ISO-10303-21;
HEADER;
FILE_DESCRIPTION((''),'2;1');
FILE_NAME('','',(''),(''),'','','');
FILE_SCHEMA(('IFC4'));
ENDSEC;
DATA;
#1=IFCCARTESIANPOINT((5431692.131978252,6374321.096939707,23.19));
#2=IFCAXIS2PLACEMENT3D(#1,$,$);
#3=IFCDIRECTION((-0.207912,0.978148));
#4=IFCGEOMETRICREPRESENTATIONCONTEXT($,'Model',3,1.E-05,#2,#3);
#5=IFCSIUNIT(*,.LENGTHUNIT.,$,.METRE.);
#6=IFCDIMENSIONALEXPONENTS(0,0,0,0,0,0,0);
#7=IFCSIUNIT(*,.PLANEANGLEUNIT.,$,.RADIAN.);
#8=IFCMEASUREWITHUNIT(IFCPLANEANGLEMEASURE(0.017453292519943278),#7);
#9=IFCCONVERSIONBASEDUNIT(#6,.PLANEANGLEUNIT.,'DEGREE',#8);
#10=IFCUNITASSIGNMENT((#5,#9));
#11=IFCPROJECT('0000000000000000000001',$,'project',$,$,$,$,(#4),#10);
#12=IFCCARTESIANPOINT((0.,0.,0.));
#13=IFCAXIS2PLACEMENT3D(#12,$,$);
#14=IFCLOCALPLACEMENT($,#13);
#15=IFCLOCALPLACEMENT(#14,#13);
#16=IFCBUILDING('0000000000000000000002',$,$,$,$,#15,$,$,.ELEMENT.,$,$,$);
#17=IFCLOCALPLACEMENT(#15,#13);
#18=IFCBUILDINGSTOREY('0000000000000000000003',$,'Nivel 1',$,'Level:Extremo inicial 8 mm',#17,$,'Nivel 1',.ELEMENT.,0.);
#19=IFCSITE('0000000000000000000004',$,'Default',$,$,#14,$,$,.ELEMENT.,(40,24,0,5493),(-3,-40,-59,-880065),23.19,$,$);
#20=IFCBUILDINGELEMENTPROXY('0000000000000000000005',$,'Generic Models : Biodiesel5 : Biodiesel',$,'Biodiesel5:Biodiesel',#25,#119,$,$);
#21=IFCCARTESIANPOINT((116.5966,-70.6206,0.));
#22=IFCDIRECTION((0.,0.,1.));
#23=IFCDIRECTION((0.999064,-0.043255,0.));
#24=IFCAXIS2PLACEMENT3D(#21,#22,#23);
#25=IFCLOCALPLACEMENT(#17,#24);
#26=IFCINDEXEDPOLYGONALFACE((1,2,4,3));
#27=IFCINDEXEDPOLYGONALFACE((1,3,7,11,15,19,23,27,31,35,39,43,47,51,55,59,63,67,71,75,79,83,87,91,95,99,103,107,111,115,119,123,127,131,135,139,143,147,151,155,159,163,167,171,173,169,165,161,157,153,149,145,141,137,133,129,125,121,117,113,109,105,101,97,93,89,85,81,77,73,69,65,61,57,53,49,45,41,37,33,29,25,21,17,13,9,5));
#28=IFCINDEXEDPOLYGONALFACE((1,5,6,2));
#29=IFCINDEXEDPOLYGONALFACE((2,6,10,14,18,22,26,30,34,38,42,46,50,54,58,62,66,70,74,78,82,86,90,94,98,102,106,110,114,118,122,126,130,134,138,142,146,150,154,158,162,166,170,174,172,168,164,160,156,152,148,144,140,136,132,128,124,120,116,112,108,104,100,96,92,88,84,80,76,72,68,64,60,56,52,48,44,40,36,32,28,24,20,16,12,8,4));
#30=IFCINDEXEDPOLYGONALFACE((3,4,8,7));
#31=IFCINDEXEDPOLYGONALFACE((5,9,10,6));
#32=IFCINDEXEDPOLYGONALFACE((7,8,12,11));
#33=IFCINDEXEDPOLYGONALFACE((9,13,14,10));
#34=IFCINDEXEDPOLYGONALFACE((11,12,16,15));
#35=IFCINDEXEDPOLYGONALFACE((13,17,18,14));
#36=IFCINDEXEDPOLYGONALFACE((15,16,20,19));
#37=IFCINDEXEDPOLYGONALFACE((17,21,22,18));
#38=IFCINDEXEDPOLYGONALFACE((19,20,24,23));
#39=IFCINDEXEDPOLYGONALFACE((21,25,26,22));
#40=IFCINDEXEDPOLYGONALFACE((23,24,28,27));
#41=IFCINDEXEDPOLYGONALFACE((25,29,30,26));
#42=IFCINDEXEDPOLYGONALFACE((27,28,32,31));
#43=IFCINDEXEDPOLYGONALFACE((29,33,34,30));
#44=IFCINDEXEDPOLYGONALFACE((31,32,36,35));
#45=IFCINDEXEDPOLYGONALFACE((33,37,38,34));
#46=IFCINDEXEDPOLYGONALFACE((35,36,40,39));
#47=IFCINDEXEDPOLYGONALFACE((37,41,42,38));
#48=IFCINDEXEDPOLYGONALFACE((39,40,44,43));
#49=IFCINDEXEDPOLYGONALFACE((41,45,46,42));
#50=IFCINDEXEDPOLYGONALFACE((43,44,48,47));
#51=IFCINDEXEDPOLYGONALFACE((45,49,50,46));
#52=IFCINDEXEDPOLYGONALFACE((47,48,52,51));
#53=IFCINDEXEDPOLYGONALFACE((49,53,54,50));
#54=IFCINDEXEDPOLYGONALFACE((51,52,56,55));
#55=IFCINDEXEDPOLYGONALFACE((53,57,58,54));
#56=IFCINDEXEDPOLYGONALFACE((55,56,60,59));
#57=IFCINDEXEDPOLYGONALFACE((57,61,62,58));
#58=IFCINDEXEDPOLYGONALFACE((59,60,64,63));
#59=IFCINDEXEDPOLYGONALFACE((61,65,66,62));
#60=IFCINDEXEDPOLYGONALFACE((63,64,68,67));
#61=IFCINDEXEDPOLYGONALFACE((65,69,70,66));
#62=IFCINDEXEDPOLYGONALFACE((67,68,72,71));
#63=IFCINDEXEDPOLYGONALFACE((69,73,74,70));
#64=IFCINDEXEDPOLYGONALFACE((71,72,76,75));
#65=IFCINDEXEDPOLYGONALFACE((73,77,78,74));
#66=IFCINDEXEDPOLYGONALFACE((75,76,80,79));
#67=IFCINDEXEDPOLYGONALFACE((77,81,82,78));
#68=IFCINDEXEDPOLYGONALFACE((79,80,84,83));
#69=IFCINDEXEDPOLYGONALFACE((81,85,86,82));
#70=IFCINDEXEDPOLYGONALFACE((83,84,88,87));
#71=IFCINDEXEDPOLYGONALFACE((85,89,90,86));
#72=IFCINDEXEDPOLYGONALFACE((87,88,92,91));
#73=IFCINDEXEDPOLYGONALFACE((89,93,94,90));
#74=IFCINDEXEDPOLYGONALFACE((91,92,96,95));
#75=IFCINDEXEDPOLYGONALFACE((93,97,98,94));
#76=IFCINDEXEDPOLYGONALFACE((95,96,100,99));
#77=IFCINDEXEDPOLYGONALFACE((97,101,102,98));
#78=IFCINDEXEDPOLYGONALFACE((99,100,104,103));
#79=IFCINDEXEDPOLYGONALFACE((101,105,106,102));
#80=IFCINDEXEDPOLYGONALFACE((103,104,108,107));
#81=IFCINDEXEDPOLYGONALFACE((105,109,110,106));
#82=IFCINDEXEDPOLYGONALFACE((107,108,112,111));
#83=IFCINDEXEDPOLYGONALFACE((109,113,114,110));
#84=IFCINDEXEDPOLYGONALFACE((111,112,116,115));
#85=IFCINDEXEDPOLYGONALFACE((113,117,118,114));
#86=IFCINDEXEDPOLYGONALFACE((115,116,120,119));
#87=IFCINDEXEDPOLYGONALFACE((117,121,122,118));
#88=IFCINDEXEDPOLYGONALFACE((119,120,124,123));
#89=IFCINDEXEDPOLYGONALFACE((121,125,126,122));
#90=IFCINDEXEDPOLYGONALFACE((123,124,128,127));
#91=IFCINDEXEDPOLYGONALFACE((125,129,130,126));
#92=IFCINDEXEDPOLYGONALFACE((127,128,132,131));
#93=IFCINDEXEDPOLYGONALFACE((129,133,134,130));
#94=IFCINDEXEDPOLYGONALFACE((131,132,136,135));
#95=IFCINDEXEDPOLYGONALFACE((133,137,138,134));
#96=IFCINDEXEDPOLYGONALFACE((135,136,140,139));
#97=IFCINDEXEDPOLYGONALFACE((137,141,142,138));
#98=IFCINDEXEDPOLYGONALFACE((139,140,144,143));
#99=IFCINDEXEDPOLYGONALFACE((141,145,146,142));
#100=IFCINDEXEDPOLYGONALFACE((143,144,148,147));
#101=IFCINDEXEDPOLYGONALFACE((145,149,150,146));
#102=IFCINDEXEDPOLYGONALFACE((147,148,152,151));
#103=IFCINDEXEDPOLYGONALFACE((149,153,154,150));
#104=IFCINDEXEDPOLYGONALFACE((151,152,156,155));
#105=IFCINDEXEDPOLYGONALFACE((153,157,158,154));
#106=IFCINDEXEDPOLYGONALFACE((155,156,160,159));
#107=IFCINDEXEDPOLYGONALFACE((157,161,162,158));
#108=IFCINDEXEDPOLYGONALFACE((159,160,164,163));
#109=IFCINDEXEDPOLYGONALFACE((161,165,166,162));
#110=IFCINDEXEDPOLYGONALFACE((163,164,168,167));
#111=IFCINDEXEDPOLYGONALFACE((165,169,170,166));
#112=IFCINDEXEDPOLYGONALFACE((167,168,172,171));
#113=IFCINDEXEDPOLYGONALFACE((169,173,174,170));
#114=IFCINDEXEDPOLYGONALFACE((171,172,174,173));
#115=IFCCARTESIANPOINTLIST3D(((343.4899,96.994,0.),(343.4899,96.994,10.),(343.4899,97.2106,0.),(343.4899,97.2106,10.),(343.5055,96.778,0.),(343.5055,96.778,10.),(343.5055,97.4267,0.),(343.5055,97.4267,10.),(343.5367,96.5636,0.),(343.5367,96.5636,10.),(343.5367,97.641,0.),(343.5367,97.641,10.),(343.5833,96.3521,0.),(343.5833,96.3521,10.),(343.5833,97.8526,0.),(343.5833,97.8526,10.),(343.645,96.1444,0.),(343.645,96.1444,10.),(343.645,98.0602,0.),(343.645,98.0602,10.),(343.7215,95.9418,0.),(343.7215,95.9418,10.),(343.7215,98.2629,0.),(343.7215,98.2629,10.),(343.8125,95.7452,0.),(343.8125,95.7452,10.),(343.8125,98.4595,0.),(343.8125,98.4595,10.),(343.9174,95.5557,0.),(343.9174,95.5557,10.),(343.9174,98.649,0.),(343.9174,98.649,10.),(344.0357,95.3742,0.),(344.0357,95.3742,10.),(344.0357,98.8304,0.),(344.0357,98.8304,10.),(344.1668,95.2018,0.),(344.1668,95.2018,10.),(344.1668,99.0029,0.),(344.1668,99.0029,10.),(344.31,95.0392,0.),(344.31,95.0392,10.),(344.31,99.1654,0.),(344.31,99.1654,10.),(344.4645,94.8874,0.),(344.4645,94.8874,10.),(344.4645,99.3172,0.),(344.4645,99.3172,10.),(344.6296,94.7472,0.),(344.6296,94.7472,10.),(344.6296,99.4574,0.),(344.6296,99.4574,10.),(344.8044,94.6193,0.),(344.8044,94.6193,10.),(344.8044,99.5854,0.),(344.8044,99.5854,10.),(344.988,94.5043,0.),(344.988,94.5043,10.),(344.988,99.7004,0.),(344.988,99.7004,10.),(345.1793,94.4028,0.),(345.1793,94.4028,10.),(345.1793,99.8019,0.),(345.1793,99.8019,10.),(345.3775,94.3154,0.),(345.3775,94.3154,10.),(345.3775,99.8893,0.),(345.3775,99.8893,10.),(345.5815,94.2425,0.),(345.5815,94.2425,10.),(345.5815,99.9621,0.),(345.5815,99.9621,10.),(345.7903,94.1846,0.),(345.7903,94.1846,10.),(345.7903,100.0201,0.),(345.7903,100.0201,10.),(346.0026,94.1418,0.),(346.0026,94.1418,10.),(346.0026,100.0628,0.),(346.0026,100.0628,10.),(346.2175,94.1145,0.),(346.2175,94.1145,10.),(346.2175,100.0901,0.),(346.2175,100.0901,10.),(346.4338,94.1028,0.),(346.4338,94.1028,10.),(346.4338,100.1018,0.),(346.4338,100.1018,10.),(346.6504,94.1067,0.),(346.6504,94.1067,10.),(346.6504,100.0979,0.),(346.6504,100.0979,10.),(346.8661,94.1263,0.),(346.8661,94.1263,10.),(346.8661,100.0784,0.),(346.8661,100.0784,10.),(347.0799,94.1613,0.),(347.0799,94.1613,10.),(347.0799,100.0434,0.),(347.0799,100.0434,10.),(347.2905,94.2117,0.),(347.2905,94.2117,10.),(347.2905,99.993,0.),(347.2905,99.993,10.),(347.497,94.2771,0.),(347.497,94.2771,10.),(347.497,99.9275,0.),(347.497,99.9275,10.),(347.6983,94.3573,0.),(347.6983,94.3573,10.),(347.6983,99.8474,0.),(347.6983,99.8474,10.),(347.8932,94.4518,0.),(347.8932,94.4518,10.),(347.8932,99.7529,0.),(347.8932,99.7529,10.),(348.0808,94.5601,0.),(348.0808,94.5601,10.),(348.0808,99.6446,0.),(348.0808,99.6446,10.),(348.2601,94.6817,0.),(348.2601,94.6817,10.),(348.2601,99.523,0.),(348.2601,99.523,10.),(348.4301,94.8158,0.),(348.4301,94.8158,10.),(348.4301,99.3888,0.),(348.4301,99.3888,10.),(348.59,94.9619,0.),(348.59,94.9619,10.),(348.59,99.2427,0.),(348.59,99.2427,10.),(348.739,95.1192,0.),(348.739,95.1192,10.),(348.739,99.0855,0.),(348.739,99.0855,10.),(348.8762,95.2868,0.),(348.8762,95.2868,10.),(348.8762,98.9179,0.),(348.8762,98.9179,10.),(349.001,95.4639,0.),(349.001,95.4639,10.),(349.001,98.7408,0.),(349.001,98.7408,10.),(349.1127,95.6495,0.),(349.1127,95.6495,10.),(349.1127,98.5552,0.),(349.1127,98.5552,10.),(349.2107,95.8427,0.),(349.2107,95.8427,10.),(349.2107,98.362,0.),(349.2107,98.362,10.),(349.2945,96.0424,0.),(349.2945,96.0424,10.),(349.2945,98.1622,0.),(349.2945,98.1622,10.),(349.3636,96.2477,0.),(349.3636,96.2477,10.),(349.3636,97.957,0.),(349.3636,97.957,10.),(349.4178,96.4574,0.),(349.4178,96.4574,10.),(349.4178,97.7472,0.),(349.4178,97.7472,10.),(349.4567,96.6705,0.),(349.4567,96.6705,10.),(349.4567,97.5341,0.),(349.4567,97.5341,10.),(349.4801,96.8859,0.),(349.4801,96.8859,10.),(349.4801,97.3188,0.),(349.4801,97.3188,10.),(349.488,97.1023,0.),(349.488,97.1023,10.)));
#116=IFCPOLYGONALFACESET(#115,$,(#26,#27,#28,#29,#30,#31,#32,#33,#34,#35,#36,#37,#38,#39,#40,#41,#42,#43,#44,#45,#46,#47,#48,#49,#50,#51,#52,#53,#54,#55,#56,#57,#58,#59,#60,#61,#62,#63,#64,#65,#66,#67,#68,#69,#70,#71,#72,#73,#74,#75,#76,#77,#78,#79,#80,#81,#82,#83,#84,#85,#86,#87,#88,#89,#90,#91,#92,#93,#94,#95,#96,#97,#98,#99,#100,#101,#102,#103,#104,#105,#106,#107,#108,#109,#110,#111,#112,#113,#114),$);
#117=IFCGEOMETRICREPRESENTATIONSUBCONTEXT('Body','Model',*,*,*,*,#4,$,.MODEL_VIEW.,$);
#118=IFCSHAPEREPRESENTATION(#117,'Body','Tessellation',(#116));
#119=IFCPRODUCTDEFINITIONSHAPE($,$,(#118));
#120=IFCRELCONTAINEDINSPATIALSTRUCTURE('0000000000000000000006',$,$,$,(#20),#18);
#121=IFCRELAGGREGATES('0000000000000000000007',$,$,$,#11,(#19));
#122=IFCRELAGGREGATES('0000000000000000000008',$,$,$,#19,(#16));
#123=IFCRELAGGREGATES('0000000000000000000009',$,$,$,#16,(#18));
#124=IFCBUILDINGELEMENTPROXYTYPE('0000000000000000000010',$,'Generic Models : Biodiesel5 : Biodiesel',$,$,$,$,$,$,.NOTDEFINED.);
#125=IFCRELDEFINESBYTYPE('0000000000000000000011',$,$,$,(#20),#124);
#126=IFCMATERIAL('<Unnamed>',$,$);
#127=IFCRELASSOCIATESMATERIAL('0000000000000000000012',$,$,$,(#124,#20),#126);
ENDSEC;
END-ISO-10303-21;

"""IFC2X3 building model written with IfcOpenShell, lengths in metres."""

from ifc_helpers import new_model, entity, si_unit, converted_unit, direction, frame, frame_2d, origin, place, context, subcontext, project, spatial, circle, extrude, source, transform, mapped, material, type_object, type_shapes, element, save


model = new_model("IFC2X3")

# Units and contexts
model_context = context("Model", 3, precision=1e-05, world=frame((5431692.131978252, 6374321.096939707, 23.19)), true_north=direction((-0.207912, 0.978148)))
body_context = subcontext(model_context, "Body", "Model", "MODEL_VIEW")
ifc_project = project(units=[si_unit("LENGTHUNIT", "METRE"), converted_unit("PLANEANGLEUNIT", "DEGREE", entity("IfcPlaneAngleMeasure", 0.017453292519943278), si_unit("PLANEANGLEUNIT", "RADIAN"), dimensions=[0, 0, 0, 0, 0, 0, 0])], contexts=[model_context])

# Site, building, storey
site_placement = place(None, origin())
site = spatial("IfcSite", under=ifc_project, at=site_placement, Name="Default", CompositionType="ELEMENT", RefLatitude=(40, 24, 0, 5493), RefLongitude=(-3, -40, -59, -880065), RefElevation=23.19)
building_placement = place(site_placement, origin())
building = spatial("IfcBuilding", under=site, at=building_placement, CompositionType="ELEMENT")
storey_placement = place(building_placement, origin())
storey = spatial("IfcBuildingStorey", under=building, at=storey_placement, Name="Nivel 1", ObjectType="Level:Extremo inicial 8 mm", LongName="Nivel 1", CompositionType="ELEMENT", Elevation=0.0)

# Building element proxy
ifc_material_1 = material(Name="<Unnamed>")
building_element_proxy_type_1 = type_object("IfcBuildingElementProxyType", Name="Generic Models : Biodiesel5 : Biodiesel", PredefinedType="NOTDEFINED", material=ifc_material_1)
shared_shape_1 = source(origin(), body_context, "Body", "SweptSolid", [
    extrude(circle(Radius=3.0, at=frame_2d((0.0, 0.0), x_axis=(1.0, 0.0))), frame((346.488, 97.1023, 0.0)), (0.0, 0.0, 1.0), 10.0),
])
type_shapes(building_element_proxy_type_1, [shared_shape_1])
proxy_1_placement = place(storey_placement, frame((116.5966, -70.6206, 0.0), z_axis=(0.0, 0.0, 1.0), x_axis=(0.999064, -0.043255, 0.0)))
element("IfcBuildingElementProxy", 1, at=proxy_1_placement, inside=storey, type_object=building_element_proxy_type_1, material=ifc_material_1, Name="Generic Models : Biodiesel5 : Biodiesel", ObjectType="Biodiesel5:Biodiesel", context=body_context, shape_type="MappedRepresentation", body=[
    mapped(shared_shape_1, transform((0.0, 0.0, 0.0), scale=1.0)),
])

save(model, "model.ifc")
